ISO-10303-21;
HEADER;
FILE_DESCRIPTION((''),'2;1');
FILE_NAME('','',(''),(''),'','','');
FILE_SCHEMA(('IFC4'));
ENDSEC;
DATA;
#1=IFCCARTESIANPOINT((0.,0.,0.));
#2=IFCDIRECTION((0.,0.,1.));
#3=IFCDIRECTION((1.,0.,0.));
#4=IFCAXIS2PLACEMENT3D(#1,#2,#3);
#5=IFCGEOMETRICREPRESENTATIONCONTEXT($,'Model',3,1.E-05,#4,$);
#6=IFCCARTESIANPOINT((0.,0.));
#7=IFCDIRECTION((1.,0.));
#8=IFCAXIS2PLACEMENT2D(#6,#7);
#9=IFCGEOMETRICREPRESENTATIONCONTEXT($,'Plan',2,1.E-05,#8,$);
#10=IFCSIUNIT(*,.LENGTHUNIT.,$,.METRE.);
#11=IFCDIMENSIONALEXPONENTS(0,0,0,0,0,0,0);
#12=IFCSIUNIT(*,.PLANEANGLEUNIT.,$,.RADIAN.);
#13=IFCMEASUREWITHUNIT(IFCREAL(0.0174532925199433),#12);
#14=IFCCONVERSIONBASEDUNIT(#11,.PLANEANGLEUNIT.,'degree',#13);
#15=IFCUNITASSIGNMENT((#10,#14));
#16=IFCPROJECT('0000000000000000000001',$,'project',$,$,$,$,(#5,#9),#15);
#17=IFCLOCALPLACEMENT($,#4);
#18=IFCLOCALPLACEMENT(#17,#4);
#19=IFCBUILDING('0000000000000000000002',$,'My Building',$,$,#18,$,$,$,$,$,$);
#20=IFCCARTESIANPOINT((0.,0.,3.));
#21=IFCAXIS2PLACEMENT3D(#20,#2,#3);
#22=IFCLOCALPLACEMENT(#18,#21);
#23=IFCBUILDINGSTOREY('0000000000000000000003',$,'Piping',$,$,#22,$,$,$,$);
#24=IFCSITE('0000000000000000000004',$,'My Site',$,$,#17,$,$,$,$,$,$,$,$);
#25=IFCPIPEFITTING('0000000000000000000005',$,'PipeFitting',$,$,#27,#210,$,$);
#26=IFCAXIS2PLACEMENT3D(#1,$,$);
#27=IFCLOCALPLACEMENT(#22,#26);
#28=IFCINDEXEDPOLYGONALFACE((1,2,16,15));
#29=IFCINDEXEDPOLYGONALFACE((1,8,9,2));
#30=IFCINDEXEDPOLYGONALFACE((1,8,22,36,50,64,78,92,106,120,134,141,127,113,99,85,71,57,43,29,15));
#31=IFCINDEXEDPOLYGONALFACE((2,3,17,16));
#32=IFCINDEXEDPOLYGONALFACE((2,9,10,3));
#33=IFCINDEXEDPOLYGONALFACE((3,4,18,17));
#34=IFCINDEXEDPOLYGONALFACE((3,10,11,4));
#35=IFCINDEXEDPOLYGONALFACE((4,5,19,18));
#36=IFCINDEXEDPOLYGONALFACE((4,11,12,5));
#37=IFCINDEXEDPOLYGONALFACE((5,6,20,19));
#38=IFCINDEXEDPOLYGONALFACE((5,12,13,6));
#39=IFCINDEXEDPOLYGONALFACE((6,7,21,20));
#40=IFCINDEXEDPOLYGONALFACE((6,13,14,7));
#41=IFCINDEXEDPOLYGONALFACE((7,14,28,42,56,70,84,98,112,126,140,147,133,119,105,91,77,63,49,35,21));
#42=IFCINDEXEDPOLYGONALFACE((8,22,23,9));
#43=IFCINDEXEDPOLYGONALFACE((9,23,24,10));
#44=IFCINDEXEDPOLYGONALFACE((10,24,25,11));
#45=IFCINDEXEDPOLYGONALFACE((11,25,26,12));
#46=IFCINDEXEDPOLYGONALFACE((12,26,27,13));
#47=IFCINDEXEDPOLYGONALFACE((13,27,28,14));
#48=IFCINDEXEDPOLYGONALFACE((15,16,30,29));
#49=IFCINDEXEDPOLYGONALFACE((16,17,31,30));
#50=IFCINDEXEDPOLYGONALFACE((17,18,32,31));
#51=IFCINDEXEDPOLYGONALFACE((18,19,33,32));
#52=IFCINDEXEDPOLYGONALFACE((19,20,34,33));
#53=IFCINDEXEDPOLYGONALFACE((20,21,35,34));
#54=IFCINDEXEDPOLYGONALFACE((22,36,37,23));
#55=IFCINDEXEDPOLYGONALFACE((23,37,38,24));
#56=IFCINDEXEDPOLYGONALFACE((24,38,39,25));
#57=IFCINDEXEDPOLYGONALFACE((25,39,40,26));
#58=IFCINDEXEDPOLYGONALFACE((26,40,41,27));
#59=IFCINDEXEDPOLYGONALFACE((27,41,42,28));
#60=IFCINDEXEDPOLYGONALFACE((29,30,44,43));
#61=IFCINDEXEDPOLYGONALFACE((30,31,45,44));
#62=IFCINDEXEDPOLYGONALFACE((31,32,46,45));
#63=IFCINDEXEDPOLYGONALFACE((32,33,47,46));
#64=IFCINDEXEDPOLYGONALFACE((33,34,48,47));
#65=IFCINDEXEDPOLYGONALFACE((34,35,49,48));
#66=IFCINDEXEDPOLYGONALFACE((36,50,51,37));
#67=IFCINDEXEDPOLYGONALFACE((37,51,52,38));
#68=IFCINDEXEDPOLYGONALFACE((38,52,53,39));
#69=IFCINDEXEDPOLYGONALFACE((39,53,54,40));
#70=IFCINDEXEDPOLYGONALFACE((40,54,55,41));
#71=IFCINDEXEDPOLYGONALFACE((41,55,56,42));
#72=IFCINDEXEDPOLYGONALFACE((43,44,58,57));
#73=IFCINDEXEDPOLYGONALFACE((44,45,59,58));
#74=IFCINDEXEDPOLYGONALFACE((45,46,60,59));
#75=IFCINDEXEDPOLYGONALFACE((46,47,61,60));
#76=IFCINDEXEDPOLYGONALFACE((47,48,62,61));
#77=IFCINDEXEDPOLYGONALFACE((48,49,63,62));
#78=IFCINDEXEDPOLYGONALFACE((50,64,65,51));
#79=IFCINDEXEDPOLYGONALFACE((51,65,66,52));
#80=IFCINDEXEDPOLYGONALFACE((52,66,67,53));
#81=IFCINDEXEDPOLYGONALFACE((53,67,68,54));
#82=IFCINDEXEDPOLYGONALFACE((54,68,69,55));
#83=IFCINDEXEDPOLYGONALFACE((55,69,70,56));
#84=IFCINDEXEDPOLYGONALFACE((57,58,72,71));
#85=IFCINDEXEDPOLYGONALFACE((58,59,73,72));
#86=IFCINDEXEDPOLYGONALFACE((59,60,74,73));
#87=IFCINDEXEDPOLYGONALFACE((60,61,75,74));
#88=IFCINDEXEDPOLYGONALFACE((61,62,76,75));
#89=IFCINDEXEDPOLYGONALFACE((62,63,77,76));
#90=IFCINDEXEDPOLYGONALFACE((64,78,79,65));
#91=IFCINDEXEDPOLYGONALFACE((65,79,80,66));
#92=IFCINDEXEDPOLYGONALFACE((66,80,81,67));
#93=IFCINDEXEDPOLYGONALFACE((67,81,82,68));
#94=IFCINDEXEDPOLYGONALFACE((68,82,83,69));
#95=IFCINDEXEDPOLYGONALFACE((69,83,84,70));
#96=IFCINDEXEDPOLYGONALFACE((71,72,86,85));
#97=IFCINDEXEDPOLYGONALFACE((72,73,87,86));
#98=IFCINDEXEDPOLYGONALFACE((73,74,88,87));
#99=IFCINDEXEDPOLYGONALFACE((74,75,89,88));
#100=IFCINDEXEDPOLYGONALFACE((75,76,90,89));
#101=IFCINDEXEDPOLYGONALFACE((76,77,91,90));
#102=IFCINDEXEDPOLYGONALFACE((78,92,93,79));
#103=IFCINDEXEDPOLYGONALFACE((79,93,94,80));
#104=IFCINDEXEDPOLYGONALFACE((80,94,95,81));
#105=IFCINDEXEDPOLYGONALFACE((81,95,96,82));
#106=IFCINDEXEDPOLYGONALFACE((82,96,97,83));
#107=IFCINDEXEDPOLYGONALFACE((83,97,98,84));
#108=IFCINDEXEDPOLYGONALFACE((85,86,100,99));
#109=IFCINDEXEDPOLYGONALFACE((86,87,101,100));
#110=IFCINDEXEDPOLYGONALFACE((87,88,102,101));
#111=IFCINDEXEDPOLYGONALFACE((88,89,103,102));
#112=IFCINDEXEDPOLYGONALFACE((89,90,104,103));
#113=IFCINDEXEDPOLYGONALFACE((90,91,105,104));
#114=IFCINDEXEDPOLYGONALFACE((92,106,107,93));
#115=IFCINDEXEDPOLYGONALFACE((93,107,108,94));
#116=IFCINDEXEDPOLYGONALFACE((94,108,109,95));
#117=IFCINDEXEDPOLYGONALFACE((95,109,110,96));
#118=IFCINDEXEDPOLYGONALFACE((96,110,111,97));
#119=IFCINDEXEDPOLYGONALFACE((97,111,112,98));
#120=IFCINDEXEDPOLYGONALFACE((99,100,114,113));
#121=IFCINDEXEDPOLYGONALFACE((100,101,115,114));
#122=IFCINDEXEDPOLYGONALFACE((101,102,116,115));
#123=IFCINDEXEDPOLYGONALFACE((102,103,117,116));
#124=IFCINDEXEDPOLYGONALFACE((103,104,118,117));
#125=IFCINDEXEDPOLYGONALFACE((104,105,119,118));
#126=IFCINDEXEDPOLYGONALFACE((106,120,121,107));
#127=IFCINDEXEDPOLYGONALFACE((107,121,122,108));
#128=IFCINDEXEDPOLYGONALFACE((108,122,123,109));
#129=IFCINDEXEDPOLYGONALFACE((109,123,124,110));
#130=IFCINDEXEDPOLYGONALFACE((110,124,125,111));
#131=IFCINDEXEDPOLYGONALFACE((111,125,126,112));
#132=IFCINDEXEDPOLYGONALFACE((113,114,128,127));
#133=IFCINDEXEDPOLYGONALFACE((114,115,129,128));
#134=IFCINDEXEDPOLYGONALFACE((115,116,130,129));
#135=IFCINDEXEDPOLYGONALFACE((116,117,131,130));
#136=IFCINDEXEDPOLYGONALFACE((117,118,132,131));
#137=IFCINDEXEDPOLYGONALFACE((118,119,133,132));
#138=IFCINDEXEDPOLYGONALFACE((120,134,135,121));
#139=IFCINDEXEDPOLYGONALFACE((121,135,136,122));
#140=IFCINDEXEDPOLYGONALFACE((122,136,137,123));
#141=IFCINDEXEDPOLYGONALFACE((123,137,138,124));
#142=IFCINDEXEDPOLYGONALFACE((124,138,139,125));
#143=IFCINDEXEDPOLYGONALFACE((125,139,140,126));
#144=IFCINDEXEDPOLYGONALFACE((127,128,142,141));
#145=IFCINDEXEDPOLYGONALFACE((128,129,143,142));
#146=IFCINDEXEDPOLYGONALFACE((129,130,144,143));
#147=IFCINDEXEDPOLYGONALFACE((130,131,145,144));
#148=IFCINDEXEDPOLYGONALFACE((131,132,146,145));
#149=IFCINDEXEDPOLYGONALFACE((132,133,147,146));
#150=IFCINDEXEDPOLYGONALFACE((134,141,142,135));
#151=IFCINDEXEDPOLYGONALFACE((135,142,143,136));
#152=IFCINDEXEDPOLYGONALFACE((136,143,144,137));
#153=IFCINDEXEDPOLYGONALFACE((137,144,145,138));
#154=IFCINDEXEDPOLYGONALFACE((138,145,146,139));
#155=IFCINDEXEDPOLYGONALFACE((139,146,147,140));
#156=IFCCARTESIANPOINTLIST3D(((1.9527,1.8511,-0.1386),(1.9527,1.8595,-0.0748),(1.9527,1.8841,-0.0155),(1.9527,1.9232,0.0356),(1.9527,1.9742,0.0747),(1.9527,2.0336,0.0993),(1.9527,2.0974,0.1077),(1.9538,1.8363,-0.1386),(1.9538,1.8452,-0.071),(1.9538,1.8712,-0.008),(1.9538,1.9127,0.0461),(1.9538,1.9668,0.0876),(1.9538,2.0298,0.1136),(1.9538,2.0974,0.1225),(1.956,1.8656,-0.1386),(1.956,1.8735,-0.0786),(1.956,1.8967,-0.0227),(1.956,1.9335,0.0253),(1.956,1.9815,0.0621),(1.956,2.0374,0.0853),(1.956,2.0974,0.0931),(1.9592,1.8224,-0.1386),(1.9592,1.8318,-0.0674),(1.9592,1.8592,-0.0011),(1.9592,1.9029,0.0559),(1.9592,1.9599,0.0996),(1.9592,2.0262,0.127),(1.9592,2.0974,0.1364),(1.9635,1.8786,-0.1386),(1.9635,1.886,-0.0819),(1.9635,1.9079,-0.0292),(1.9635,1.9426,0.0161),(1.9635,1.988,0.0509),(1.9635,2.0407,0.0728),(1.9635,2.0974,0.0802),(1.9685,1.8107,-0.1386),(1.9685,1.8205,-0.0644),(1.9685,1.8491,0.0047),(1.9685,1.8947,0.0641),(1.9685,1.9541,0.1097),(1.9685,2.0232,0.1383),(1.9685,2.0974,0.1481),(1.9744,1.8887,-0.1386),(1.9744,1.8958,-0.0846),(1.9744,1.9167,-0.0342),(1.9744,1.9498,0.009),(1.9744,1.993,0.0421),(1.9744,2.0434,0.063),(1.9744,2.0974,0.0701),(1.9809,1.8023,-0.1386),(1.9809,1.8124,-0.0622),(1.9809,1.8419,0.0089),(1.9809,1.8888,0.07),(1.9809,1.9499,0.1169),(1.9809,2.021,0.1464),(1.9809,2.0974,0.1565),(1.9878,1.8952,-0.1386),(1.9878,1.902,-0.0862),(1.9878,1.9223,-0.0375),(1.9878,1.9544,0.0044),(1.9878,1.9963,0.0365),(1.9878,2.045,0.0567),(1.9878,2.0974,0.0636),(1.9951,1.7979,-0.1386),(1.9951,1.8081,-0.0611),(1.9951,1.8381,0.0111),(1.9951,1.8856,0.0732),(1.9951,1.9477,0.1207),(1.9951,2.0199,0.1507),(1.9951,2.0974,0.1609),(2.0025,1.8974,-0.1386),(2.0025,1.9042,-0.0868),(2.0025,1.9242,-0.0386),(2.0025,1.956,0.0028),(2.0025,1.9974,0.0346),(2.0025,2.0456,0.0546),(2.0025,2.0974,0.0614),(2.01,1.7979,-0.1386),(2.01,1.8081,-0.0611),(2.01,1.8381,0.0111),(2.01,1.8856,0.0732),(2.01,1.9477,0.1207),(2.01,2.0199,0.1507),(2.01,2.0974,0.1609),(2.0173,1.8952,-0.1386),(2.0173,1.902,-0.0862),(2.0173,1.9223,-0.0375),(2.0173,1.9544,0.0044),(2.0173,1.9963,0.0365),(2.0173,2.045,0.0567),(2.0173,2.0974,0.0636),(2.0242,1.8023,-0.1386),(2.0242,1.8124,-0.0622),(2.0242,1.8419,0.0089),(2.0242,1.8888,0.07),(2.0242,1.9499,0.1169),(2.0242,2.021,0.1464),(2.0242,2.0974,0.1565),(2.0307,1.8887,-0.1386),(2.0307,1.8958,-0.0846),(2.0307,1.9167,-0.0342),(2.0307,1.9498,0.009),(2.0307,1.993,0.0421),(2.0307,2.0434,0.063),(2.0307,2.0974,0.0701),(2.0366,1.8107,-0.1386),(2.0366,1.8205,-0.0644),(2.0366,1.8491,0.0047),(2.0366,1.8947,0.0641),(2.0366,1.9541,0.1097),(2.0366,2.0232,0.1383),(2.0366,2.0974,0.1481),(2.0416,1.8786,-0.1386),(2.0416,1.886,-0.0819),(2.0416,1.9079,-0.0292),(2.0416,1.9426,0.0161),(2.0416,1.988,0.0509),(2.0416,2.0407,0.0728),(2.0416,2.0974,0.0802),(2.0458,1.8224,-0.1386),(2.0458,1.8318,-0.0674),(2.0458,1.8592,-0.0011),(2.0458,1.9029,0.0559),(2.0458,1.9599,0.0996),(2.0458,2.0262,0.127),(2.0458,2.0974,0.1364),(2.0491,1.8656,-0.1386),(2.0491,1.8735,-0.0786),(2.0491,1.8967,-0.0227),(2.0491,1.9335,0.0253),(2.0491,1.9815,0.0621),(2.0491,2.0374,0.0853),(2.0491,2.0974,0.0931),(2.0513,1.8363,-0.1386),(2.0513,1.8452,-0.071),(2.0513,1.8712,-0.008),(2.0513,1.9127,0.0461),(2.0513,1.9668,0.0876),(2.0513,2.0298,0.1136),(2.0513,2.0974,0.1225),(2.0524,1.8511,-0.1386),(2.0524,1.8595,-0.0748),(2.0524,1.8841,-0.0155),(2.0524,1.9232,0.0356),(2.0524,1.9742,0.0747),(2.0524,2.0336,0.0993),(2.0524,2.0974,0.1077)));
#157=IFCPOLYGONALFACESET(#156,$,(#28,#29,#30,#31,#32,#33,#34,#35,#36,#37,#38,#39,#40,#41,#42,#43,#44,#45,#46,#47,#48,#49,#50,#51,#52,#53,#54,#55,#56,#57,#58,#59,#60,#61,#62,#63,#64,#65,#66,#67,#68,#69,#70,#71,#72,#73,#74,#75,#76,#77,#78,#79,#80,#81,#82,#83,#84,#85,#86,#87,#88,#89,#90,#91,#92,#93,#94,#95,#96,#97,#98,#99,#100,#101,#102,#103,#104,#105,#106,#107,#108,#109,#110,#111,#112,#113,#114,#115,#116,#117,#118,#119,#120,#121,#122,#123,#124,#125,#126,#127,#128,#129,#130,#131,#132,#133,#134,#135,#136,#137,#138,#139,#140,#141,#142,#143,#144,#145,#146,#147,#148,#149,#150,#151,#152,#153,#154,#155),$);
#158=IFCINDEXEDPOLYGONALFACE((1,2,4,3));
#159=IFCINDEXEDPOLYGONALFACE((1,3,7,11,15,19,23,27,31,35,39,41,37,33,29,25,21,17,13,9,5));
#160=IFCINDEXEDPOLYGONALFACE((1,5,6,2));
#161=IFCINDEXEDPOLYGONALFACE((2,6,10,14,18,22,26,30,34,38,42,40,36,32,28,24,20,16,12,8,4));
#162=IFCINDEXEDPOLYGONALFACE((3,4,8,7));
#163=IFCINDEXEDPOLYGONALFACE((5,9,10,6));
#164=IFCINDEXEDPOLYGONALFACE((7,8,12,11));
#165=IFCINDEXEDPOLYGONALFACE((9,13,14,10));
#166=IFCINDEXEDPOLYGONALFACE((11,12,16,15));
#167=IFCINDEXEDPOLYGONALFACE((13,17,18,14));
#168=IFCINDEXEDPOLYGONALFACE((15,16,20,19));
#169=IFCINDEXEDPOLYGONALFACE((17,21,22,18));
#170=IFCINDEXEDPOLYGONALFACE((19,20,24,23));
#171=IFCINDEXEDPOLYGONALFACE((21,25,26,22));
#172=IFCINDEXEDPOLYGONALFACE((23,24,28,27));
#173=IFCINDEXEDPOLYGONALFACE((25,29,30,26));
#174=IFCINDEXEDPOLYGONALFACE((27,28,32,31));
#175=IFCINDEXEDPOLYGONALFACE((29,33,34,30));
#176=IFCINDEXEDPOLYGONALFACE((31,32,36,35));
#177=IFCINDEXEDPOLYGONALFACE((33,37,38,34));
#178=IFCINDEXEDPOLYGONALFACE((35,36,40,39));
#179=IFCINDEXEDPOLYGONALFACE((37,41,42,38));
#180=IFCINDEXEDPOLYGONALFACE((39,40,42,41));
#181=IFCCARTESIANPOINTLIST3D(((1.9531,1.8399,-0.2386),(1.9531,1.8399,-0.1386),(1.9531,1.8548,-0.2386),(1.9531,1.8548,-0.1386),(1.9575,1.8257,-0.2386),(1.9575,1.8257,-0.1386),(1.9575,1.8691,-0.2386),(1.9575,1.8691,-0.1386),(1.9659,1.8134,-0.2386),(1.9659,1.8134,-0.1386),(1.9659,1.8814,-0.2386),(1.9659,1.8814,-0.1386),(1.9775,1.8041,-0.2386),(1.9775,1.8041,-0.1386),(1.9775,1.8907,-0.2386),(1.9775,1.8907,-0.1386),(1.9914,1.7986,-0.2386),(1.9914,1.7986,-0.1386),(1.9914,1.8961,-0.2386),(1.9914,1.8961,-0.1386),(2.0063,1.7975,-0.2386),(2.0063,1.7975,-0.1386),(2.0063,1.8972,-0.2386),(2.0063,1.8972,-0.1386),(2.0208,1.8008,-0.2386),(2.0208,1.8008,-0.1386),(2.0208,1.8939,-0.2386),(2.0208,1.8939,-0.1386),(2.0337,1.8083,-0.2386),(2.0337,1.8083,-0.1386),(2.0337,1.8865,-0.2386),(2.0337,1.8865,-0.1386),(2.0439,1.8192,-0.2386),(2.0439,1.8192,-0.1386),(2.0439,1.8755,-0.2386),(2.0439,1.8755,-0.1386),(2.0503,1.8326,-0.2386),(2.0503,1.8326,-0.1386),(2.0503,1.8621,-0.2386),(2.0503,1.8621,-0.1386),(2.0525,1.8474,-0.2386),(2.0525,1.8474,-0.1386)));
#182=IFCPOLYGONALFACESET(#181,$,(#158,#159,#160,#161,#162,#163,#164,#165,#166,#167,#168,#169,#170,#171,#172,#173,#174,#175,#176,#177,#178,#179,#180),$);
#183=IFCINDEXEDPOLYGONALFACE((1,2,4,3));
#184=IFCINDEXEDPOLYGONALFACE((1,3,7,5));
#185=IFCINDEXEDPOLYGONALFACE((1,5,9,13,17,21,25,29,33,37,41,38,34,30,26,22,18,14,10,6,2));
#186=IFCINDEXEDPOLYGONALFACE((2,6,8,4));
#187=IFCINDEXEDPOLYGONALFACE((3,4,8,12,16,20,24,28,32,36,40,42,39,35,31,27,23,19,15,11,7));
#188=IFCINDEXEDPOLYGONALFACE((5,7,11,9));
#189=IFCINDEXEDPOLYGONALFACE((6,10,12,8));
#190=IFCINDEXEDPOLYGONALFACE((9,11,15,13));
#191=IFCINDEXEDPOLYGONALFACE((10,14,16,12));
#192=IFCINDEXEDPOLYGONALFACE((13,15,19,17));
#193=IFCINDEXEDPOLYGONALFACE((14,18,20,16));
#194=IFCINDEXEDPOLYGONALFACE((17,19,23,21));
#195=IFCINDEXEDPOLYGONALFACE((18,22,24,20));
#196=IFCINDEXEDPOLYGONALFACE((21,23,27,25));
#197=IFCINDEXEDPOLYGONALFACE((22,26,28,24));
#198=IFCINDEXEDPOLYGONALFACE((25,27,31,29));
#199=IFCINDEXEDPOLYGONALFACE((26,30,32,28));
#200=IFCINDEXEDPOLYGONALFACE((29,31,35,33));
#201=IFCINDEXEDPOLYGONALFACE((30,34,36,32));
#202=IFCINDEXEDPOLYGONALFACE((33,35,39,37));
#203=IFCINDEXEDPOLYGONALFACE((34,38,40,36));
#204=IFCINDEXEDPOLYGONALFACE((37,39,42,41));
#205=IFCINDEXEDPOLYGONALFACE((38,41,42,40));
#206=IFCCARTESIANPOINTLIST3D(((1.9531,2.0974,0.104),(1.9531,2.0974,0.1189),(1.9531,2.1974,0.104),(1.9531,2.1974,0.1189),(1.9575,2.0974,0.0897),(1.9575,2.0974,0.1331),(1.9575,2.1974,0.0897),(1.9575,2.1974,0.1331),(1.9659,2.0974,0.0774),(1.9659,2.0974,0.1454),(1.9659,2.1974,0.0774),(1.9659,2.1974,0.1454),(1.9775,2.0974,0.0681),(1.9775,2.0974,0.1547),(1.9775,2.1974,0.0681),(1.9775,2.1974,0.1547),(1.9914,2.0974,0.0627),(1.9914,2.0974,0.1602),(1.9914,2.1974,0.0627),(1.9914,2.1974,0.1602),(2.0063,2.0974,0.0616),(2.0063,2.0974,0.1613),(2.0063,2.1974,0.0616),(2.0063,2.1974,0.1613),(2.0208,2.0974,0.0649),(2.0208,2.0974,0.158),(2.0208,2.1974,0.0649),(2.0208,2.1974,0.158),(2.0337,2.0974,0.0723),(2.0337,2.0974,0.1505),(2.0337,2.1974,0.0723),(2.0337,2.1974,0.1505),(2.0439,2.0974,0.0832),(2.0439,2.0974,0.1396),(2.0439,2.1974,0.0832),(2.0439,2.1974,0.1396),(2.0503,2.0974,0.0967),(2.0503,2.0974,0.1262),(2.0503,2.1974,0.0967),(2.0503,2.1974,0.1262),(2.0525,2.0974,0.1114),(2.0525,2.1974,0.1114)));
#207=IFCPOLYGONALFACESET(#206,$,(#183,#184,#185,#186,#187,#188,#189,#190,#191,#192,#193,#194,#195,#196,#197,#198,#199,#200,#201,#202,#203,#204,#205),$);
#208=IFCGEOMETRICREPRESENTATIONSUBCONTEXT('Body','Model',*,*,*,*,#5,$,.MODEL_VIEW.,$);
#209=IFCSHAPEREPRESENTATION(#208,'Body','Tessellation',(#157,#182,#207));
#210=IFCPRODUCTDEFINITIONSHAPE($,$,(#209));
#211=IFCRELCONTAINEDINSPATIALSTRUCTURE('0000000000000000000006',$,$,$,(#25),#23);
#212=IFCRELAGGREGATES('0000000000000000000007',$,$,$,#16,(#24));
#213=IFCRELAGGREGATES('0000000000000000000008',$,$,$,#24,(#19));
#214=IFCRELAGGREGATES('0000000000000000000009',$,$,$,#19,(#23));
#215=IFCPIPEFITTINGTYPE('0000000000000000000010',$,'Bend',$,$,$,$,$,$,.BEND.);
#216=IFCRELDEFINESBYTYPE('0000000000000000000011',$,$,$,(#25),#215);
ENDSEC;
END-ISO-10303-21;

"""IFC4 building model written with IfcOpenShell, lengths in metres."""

from ifc_helpers import new_model, entity, si_unit, converted_unit, frame, origin_with_axes, origin_2d_with_axis, place, context, subcontext, project, spatial, circle, extrude, source, transform, mapped, type_object, type_shapes, element, save


model = new_model("IFC4")

# Units and contexts
model_context = context("Model", 3, precision=1e-05, world=origin_with_axes())
plan_context = context("Plan", 2, precision=1e-05, world=origin_2d_with_axis())
body_context = subcontext(model_context, "Body", "Model", "MODEL_VIEW")
ifc_project = project(units=[si_unit("LENGTHUNIT", "METRE"), converted_unit("PLANEANGLEUNIT", "degree", entity("IfcReal", 0.0174532925199433), si_unit("PLANEANGLEUNIT", "RADIAN"), dimensions=[0, 0, 0, 0, 0, 0, 0])], contexts=[model_context, plan_context])

# Site, building, storey
site_placement = place(None, origin_with_axes())
site = spatial("IfcSite", under=ifc_project, at=site_placement, Name="My Site")
building_placement = place(site_placement, origin_with_axes())
building = spatial("IfcBuilding", under=site, at=building_placement, Name="My Building")
storey_placement = place(building_placement, frame((0.0, 0.0, 3.0), z_axis=(0.0, 0.0, 1.0), x_axis=(1.0, 0.0, 0.0)))
storey = spatial("IfcBuildingStorey", under=building, at=storey_placement, Name="Piping")

# Pipe fitting
pipe_fitting_type_1 = type_object("IfcPipeFittingType", Name="Bend", PredefinedType="BEND")
shared_shape = source(origin_with_axes(), body_context, "Body", "SolidModel", [
    entity("IfcSweptDiskSolid", entity("IfcIndexedPolyCurve", entity("IfcCartesianPointList3D", [[0.0, 0.0, -0.1], [0.0, -0.0732, -0.2768], [0.0, -0.25, -0.35]]), [entity("IfcArcIndex", [1, 2, 3])]), 0.05),
    extrude(circle(Radius=0.05), origin_with_axes(), (0.0, 0.0, -1.0), 0.1),
    extrude(circle(Radius=0.05), frame((0.0, -0.25, -0.35), z_axis=(0.0, -1.0, 0.0), x_axis=(1.0, 0.0, 0.0)), (0.0, 0.0, 1.0), 0.1),
])
type_shapes(pipe_fitting_type_1, [shared_shape])
for number, where, z_axis, x_axis, name in (
    (1, (2.0025, 1.8474, -0.2386), (0.0, 0.0, -1.0), (1.0, 0.0, 0.0), "PipeFitting"),
):
    element("IfcPipeFitting", number, at=place(storey_placement, frame(where, z_axis=z_axis, x_axis=x_axis)), inside=storey, type_object=pipe_fitting_type_1, Name=name, context=body_context, shape_type="MappedRepresentation", body=[
        mapped(shared_shape, transform((0.0, 0.0, 0.0), x_axis=(1.0, 0.0, 0.0), y_axis=(0.0, 1.0, 0.0), z_axis=(0.0, 0.0, 1.0), scale=1.0)),
    ])

save(model, "model.ifc")
